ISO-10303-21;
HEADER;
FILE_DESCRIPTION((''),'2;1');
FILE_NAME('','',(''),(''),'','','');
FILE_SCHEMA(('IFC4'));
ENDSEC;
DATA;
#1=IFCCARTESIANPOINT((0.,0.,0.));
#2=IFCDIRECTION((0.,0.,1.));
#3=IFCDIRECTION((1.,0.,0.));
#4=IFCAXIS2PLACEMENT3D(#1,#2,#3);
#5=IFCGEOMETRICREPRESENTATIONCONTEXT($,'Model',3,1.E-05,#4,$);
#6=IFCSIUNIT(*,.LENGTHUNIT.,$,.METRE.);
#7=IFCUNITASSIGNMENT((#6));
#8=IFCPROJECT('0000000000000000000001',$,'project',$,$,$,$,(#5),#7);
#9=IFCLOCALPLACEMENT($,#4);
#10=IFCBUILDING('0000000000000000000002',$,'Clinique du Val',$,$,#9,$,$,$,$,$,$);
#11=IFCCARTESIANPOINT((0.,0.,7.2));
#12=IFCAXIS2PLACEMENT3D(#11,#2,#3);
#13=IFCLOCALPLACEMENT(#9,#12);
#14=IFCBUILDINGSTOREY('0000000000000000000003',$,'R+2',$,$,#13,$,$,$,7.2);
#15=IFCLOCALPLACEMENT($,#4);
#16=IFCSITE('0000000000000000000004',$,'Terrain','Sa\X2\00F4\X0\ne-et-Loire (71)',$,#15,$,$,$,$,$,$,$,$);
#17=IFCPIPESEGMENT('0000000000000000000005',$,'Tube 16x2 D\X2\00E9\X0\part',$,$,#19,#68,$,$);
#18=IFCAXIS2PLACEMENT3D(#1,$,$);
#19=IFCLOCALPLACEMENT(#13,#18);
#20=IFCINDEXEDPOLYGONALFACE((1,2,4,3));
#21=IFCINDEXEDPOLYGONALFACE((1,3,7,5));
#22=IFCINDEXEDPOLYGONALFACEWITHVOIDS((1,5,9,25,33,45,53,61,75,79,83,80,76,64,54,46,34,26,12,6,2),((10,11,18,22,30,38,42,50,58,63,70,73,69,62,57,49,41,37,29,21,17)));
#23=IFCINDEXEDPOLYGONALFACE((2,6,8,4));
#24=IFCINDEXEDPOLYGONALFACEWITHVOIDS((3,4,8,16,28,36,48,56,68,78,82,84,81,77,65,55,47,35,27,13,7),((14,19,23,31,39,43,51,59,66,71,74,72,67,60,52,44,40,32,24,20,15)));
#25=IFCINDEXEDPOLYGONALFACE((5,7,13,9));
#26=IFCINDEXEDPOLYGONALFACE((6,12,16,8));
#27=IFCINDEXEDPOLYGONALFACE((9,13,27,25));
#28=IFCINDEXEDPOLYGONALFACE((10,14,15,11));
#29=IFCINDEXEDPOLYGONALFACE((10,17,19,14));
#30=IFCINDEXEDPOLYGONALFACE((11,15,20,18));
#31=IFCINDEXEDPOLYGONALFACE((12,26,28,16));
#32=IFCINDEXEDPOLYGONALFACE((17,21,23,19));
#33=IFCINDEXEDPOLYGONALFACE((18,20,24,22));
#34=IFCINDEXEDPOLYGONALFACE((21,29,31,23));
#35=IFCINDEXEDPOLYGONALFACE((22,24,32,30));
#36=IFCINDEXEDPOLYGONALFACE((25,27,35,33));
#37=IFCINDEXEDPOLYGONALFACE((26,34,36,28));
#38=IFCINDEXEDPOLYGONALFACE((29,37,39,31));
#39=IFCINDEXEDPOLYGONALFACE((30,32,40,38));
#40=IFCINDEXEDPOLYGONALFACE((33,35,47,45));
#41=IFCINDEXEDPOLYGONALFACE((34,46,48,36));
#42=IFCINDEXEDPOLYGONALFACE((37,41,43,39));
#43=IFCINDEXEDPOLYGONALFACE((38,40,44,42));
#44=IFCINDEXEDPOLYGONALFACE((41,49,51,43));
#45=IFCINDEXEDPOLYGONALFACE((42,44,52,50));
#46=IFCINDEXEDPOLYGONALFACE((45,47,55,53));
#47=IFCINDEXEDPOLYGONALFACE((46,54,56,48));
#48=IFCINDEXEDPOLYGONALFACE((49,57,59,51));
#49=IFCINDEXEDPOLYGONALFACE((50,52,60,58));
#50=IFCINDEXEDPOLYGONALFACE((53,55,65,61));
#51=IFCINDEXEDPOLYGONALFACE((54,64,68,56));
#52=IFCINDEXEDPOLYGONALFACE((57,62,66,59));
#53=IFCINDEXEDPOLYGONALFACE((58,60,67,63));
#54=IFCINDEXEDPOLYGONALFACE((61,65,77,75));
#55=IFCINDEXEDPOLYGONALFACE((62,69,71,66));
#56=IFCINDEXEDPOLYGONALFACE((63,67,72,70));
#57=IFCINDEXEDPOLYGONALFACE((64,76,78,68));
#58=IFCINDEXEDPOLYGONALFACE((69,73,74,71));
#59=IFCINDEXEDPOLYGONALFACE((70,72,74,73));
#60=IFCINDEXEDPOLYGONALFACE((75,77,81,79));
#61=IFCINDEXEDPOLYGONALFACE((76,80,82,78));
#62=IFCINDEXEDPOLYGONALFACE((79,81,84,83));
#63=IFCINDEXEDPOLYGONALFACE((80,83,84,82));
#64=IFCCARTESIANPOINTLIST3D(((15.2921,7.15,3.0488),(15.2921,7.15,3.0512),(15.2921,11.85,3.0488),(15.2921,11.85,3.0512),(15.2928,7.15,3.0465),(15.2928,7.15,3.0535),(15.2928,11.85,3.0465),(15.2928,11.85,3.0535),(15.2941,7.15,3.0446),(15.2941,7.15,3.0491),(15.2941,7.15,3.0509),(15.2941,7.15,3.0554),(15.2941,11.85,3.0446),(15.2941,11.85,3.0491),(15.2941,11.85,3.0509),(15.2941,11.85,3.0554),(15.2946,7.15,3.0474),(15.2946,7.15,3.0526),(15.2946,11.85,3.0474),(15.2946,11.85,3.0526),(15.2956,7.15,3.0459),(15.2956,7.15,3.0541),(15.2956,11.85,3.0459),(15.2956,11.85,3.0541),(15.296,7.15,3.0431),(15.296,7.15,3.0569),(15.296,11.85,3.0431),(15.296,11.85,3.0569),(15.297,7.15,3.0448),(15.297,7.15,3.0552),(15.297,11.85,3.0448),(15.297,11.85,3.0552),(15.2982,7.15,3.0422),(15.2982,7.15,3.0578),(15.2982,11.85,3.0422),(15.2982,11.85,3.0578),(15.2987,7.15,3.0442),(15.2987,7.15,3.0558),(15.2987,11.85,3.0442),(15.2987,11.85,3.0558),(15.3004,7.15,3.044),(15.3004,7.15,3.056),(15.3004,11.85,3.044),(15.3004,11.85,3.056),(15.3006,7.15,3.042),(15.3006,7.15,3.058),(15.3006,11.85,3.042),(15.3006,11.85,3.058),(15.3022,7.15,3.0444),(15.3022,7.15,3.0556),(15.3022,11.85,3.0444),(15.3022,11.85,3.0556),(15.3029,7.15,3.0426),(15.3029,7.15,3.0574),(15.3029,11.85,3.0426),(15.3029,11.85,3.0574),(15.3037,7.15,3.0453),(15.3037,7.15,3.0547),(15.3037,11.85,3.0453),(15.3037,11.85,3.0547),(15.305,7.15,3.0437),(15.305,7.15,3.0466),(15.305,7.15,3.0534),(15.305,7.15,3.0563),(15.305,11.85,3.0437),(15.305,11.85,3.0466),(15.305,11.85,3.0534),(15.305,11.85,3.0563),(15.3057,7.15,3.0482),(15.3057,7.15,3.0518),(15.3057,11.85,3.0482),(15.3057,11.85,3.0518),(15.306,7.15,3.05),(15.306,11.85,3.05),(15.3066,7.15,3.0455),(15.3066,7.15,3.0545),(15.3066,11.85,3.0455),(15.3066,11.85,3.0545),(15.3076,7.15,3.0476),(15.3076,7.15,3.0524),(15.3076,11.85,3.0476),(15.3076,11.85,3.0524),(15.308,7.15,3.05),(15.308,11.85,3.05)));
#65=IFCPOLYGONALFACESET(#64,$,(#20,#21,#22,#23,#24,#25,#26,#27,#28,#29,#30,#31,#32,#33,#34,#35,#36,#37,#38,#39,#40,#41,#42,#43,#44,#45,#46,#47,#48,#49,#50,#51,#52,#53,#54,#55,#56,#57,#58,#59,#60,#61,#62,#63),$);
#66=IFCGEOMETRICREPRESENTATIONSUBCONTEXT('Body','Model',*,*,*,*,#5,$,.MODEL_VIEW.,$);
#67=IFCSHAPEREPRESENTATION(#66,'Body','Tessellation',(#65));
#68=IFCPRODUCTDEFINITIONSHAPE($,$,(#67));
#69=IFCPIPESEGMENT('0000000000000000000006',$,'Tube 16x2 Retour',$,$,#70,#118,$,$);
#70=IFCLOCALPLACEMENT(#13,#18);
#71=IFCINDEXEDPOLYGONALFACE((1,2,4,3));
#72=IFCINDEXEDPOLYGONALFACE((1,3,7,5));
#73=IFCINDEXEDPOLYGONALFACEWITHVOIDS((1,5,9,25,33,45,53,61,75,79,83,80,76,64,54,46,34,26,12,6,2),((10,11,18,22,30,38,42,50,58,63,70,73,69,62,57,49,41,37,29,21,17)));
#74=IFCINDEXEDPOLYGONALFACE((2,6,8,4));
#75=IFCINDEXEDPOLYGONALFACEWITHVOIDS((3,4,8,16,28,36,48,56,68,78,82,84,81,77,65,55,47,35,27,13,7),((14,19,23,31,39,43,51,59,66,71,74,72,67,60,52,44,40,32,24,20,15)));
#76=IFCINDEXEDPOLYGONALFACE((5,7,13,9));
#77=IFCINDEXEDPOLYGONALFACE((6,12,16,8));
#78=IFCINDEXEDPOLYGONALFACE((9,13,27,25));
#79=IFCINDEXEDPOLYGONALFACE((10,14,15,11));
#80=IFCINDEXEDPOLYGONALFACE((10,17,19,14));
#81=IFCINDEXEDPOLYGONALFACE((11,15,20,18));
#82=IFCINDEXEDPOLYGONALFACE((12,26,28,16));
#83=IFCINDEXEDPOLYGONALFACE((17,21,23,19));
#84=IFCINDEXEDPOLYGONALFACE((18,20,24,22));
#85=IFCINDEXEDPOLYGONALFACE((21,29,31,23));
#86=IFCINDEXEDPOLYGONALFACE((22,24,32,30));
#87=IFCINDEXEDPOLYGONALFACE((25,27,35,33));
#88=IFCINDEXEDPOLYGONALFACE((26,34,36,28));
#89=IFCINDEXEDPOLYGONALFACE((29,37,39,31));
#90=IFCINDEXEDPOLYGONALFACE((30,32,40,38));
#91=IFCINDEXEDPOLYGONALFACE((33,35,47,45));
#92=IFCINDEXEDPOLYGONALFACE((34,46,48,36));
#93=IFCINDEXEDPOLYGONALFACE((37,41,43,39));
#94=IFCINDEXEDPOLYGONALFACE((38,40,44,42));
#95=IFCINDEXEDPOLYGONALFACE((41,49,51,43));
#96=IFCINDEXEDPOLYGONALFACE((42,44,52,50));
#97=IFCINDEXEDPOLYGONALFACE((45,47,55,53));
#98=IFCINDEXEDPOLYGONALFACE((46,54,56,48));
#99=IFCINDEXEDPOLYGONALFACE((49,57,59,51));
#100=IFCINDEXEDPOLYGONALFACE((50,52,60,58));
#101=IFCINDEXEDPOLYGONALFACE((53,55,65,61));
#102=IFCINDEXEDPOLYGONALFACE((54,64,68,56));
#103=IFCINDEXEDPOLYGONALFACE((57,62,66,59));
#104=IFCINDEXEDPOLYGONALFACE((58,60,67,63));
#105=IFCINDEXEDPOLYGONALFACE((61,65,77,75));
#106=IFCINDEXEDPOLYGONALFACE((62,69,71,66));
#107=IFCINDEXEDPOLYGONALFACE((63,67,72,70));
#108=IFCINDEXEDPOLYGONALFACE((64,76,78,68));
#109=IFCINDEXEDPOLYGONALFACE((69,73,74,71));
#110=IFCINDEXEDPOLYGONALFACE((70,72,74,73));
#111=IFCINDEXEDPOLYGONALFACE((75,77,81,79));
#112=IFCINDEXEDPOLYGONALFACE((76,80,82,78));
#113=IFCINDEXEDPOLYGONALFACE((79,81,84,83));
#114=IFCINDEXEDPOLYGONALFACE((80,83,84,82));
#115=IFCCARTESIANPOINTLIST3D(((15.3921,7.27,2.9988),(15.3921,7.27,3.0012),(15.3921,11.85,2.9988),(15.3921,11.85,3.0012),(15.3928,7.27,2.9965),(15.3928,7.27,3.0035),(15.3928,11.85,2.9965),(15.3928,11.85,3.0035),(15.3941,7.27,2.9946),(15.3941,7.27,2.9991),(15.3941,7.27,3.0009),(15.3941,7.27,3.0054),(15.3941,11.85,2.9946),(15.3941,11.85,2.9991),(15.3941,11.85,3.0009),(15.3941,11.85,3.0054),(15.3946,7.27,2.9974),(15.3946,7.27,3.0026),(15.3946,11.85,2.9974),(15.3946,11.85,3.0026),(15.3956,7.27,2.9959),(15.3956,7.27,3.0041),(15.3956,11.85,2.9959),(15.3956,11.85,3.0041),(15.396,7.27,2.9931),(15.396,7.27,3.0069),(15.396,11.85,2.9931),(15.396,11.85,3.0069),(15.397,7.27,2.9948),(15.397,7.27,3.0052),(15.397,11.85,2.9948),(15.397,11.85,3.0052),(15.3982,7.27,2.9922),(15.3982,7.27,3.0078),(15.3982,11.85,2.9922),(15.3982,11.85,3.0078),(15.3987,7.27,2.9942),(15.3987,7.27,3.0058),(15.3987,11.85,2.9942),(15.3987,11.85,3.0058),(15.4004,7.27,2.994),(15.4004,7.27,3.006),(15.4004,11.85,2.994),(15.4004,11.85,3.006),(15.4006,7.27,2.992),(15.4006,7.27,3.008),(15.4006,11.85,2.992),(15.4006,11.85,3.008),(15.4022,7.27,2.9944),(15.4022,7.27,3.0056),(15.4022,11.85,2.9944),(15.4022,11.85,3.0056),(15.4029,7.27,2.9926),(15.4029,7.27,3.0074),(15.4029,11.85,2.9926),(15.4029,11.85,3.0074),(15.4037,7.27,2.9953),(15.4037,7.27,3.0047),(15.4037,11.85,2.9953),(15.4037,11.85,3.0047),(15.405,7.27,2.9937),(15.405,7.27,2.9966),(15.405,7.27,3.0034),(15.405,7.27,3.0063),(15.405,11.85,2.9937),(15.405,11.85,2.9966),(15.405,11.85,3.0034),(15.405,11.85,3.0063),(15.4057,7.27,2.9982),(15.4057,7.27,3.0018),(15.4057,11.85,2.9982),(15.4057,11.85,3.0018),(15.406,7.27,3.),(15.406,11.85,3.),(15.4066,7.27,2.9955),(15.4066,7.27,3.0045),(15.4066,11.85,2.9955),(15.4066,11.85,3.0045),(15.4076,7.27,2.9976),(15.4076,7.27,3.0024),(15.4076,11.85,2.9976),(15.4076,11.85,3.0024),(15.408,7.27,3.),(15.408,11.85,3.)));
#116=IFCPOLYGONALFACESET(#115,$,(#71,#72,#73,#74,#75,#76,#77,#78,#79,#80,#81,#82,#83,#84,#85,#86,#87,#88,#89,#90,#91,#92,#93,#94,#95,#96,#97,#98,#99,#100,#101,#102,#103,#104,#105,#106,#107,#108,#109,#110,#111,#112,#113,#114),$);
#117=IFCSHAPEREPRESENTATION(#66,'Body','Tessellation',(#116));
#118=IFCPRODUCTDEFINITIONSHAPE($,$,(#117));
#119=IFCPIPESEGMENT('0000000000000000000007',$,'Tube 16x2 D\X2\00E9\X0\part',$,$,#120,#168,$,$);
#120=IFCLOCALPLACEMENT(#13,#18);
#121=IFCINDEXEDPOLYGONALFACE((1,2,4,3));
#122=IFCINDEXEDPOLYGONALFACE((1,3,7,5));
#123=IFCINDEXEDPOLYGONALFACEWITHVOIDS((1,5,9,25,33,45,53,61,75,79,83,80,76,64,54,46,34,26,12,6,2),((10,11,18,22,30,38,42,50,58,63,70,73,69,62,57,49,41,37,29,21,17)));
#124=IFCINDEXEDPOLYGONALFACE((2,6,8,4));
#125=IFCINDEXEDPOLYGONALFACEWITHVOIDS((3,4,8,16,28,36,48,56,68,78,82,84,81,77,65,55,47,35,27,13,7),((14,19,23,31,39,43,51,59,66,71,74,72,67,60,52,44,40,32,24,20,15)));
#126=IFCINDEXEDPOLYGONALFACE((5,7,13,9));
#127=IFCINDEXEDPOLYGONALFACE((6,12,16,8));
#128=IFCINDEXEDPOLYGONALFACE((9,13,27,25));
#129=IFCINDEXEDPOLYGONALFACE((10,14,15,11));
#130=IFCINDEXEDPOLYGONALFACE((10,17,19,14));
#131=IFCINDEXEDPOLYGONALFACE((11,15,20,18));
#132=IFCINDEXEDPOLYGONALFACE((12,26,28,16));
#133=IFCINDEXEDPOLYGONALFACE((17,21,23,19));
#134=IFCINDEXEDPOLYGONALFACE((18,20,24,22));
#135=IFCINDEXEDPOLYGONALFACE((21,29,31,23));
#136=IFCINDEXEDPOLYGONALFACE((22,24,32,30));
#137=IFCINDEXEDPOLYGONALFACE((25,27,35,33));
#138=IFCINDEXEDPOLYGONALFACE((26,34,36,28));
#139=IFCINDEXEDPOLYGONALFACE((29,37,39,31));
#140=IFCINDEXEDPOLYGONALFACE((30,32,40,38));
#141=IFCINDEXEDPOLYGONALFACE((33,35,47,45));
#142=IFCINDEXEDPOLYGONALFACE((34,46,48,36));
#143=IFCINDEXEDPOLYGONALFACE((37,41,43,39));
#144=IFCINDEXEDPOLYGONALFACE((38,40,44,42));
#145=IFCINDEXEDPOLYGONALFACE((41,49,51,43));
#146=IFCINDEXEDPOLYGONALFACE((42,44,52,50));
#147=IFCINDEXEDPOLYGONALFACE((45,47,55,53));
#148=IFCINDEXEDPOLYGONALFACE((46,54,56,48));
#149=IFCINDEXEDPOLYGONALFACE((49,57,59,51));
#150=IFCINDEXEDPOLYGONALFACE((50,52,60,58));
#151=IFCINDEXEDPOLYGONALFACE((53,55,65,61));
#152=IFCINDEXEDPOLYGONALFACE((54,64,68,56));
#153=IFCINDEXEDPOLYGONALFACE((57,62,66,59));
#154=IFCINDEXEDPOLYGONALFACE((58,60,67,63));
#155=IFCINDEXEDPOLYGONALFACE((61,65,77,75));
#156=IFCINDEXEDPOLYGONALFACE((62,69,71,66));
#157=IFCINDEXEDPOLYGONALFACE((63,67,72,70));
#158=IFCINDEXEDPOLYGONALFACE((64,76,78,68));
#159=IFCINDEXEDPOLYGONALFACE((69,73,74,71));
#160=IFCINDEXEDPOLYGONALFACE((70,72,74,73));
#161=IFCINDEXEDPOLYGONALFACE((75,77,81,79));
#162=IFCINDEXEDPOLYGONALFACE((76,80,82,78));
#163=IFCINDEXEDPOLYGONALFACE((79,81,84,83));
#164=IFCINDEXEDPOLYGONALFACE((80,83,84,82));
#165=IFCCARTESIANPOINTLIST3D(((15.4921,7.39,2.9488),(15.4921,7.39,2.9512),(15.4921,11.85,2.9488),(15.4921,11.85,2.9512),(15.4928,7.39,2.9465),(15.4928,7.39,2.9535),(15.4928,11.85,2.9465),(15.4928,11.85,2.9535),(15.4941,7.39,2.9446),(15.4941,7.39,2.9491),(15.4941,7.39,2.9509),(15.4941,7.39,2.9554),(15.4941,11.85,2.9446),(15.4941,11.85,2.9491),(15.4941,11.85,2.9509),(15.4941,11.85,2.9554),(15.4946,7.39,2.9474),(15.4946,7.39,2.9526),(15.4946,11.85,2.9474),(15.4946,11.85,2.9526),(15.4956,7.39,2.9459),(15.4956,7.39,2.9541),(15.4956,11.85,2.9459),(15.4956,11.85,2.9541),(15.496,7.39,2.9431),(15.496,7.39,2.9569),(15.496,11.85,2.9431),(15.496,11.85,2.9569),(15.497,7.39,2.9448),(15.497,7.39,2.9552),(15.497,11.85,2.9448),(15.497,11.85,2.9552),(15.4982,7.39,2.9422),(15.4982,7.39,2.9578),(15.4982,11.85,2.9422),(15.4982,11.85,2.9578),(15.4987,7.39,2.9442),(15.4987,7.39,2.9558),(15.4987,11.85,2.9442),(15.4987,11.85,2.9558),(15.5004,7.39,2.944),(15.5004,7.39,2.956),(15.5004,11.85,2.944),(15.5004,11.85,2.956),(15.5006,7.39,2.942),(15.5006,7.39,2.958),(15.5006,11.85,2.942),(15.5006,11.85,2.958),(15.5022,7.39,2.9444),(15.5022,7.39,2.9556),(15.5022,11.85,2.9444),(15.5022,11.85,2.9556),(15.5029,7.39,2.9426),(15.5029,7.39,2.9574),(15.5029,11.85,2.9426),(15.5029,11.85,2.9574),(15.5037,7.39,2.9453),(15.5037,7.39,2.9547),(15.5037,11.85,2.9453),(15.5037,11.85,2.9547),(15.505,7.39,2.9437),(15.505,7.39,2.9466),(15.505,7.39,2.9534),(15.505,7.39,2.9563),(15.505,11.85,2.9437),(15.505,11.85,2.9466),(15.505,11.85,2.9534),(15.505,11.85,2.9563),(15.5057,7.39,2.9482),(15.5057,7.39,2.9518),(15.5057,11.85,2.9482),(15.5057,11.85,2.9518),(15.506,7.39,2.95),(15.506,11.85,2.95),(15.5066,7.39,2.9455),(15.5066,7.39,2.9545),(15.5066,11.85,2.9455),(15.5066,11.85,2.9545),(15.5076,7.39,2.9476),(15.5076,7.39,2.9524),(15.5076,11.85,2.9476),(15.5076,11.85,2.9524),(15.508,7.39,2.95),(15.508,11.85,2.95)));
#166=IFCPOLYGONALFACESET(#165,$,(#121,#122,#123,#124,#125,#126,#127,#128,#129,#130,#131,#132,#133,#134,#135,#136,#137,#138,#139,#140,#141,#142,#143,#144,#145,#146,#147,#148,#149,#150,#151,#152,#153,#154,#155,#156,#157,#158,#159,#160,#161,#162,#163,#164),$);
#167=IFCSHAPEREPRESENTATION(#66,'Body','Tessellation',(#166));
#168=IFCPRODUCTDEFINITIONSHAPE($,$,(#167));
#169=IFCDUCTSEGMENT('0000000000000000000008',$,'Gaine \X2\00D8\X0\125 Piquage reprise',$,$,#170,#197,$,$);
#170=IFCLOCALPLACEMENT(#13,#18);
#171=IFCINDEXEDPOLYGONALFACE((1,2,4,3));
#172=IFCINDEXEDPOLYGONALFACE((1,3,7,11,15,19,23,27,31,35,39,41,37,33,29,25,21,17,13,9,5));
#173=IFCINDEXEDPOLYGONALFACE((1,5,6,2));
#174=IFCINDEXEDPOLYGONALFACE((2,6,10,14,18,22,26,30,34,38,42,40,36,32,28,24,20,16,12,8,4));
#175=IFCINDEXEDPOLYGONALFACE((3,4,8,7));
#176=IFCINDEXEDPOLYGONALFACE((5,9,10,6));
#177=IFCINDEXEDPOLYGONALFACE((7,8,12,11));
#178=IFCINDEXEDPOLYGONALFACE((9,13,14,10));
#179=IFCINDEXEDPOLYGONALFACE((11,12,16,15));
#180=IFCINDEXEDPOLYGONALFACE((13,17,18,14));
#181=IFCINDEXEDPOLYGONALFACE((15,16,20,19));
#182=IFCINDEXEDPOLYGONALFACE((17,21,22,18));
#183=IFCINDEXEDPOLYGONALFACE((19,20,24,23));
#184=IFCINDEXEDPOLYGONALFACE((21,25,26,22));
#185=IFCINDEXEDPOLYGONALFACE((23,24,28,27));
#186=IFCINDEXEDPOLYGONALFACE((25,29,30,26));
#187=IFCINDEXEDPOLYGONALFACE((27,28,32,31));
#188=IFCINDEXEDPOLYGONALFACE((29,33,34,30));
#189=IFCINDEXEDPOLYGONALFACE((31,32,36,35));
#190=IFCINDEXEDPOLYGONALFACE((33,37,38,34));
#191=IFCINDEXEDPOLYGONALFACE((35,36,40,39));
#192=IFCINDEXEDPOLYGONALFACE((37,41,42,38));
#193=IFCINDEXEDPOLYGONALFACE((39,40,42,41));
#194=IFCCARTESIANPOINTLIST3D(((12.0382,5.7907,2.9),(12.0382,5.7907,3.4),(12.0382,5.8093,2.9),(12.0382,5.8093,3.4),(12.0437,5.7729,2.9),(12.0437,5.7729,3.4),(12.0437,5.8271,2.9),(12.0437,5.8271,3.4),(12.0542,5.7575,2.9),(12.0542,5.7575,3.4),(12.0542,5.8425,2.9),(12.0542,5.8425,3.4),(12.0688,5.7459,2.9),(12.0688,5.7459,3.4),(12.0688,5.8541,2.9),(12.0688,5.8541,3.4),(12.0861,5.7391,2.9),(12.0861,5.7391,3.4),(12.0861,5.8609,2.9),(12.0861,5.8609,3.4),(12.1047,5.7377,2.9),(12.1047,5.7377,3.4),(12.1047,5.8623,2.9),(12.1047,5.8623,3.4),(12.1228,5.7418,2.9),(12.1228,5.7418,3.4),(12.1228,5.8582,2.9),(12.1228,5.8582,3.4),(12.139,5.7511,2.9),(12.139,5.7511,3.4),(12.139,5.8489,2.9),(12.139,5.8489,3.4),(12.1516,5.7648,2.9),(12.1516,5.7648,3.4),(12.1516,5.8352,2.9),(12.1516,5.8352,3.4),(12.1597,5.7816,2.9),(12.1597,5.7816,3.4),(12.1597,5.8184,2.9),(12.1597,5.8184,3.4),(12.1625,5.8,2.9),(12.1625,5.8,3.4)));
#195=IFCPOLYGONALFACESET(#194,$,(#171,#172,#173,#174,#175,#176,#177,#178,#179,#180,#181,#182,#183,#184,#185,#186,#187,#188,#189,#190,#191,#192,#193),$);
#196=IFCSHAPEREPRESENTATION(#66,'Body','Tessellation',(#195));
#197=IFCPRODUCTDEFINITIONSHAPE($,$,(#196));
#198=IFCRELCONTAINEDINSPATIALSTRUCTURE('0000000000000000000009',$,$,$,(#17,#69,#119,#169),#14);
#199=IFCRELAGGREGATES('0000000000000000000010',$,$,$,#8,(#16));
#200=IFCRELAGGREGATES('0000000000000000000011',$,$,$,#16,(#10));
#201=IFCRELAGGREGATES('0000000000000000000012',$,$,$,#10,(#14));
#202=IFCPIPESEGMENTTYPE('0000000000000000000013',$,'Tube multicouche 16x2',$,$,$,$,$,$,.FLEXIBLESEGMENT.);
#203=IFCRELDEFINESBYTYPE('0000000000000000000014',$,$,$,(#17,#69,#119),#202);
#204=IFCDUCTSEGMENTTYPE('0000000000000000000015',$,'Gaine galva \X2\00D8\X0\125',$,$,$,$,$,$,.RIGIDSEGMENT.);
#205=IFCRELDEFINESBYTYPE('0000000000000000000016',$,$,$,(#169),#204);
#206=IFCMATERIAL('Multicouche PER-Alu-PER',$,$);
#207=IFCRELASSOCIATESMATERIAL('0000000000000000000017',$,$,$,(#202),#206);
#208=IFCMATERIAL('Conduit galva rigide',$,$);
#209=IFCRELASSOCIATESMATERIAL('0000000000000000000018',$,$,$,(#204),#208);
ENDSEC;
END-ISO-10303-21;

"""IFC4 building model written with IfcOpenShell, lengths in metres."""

from ifc_helpers import new_model, si_unit, frame, origin_with_axes, place, context, subcontext, project, spatial, circle, hollow_circle, extrude, material, type_object, element, save


model = new_model("IFC4")

# Units and contexts
model_context = context("Model", 3, precision=1e-05, world=origin_with_axes())
body_context = subcontext(model_context, "Body", "Model", "MODEL_VIEW")
ifc_project = project(units=[si_unit("LENGTHUNIT", "METRE")], contexts=[model_context])

# Site, building, storey
site_placement = place(None, origin_with_axes())
site = spatial("IfcSite", under=ifc_project, at=site_placement, Name="Terrain", Description="Saône-et-Loire (71)")
building_placement = place(None, origin_with_axes())
building = spatial("IfcBuilding", under=site, at=building_placement, Name="Clinique du Val")
storey_placement = place(building_placement, frame((0.0, 0.0, 7.2), z_axis=(0.0, 0.0, 1.0), x_axis=(1.0, 0.0, 0.0)))
storey = spatial("IfcBuildingStorey", under=building, at=storey_placement, Name="R+2", Elevation=7.2)

# Pipe segments
ifc_material_1 = material(Name="Multicouche PER-Alu-PER")
pipe_segment_type_1 = type_object("IfcPipeSegmentType", Name="Tube multicouche 16x2", PredefinedType="FLEXIBLESEGMENT", material=ifc_material_1)
pipe_segment_1_placement = place(storey_placement, frame((15.3, 7.15, 3.05), z_axis=(0.0, 1.0, 0.0), x_axis=(1.0, 0.0, 0.0)))
element("IfcPipeSegment", 1, at=pipe_segment_1_placement, inside=storey, type_object=pipe_segment_type_1, Name="Tube 16x2 Départ", context=body_context, shape_type="SweptSolid", body=[
    extrude(hollow_circle(Radius=0.008, WallThickness=0.002), origin_with_axes(), (0.0, 0.0, 1.0), 4.7),
])
pipe_segment_2_placement = place(storey_placement, frame((15.4, 7.27, 3.0), z_axis=(0.0, 1.0, 0.0), x_axis=(1.0, 0.0, 0.0)))
element("IfcPipeSegment", 2, at=pipe_segment_2_placement, inside=storey, type_object=pipe_segment_type_1, Name="Tube 16x2 Retour", context=body_context, shape_type="SweptSolid", body=[
    extrude(hollow_circle(Radius=0.008, WallThickness=0.002), origin_with_axes(), (0.0, 0.0, 1.0), 4.58),
])
pipe_segment_3_placement = place(storey_placement, frame((15.5, 7.39, 2.95), z_axis=(0.0, 1.0, 0.0), x_axis=(1.0, 0.0, 0.0)))
element("IfcPipeSegment", 3, at=pipe_segment_3_placement, inside=storey, type_object=pipe_segment_type_1, Name="Tube 16x2 Départ", context=body_context, shape_type="SweptSolid", body=[
    extrude(hollow_circle(Radius=0.008, WallThickness=0.002), origin_with_axes(), (0.0, 0.0, 1.0), 4.46),
])

# Duct segment
ifc_material_2 = material(Name="Conduit galva rigide")
duct_segment_type = type_object("IfcDuctSegmentType", Name="Gaine galva Ø125", PredefinedType="RIGIDSEGMENT", material=ifc_material_2)
duct_segment_1_placement = place(storey_placement, frame((12.1, 5.8, 3.4), z_axis=(0.0, 0.0, -1.0), x_axis=(1.0, 0.0, 0.0)))
element("IfcDuctSegment", 4, at=duct_segment_1_placement, inside=storey, type_object=duct_segment_type, Name="Gaine Ø125 Piquage reprise", context=body_context, shape_type="SweptSolid", body=[
    extrude(circle(Radius=0.0625), origin_with_axes(), (0.0, 0.0, 1.0), 0.5),
])

save(model, "model.ifc")
